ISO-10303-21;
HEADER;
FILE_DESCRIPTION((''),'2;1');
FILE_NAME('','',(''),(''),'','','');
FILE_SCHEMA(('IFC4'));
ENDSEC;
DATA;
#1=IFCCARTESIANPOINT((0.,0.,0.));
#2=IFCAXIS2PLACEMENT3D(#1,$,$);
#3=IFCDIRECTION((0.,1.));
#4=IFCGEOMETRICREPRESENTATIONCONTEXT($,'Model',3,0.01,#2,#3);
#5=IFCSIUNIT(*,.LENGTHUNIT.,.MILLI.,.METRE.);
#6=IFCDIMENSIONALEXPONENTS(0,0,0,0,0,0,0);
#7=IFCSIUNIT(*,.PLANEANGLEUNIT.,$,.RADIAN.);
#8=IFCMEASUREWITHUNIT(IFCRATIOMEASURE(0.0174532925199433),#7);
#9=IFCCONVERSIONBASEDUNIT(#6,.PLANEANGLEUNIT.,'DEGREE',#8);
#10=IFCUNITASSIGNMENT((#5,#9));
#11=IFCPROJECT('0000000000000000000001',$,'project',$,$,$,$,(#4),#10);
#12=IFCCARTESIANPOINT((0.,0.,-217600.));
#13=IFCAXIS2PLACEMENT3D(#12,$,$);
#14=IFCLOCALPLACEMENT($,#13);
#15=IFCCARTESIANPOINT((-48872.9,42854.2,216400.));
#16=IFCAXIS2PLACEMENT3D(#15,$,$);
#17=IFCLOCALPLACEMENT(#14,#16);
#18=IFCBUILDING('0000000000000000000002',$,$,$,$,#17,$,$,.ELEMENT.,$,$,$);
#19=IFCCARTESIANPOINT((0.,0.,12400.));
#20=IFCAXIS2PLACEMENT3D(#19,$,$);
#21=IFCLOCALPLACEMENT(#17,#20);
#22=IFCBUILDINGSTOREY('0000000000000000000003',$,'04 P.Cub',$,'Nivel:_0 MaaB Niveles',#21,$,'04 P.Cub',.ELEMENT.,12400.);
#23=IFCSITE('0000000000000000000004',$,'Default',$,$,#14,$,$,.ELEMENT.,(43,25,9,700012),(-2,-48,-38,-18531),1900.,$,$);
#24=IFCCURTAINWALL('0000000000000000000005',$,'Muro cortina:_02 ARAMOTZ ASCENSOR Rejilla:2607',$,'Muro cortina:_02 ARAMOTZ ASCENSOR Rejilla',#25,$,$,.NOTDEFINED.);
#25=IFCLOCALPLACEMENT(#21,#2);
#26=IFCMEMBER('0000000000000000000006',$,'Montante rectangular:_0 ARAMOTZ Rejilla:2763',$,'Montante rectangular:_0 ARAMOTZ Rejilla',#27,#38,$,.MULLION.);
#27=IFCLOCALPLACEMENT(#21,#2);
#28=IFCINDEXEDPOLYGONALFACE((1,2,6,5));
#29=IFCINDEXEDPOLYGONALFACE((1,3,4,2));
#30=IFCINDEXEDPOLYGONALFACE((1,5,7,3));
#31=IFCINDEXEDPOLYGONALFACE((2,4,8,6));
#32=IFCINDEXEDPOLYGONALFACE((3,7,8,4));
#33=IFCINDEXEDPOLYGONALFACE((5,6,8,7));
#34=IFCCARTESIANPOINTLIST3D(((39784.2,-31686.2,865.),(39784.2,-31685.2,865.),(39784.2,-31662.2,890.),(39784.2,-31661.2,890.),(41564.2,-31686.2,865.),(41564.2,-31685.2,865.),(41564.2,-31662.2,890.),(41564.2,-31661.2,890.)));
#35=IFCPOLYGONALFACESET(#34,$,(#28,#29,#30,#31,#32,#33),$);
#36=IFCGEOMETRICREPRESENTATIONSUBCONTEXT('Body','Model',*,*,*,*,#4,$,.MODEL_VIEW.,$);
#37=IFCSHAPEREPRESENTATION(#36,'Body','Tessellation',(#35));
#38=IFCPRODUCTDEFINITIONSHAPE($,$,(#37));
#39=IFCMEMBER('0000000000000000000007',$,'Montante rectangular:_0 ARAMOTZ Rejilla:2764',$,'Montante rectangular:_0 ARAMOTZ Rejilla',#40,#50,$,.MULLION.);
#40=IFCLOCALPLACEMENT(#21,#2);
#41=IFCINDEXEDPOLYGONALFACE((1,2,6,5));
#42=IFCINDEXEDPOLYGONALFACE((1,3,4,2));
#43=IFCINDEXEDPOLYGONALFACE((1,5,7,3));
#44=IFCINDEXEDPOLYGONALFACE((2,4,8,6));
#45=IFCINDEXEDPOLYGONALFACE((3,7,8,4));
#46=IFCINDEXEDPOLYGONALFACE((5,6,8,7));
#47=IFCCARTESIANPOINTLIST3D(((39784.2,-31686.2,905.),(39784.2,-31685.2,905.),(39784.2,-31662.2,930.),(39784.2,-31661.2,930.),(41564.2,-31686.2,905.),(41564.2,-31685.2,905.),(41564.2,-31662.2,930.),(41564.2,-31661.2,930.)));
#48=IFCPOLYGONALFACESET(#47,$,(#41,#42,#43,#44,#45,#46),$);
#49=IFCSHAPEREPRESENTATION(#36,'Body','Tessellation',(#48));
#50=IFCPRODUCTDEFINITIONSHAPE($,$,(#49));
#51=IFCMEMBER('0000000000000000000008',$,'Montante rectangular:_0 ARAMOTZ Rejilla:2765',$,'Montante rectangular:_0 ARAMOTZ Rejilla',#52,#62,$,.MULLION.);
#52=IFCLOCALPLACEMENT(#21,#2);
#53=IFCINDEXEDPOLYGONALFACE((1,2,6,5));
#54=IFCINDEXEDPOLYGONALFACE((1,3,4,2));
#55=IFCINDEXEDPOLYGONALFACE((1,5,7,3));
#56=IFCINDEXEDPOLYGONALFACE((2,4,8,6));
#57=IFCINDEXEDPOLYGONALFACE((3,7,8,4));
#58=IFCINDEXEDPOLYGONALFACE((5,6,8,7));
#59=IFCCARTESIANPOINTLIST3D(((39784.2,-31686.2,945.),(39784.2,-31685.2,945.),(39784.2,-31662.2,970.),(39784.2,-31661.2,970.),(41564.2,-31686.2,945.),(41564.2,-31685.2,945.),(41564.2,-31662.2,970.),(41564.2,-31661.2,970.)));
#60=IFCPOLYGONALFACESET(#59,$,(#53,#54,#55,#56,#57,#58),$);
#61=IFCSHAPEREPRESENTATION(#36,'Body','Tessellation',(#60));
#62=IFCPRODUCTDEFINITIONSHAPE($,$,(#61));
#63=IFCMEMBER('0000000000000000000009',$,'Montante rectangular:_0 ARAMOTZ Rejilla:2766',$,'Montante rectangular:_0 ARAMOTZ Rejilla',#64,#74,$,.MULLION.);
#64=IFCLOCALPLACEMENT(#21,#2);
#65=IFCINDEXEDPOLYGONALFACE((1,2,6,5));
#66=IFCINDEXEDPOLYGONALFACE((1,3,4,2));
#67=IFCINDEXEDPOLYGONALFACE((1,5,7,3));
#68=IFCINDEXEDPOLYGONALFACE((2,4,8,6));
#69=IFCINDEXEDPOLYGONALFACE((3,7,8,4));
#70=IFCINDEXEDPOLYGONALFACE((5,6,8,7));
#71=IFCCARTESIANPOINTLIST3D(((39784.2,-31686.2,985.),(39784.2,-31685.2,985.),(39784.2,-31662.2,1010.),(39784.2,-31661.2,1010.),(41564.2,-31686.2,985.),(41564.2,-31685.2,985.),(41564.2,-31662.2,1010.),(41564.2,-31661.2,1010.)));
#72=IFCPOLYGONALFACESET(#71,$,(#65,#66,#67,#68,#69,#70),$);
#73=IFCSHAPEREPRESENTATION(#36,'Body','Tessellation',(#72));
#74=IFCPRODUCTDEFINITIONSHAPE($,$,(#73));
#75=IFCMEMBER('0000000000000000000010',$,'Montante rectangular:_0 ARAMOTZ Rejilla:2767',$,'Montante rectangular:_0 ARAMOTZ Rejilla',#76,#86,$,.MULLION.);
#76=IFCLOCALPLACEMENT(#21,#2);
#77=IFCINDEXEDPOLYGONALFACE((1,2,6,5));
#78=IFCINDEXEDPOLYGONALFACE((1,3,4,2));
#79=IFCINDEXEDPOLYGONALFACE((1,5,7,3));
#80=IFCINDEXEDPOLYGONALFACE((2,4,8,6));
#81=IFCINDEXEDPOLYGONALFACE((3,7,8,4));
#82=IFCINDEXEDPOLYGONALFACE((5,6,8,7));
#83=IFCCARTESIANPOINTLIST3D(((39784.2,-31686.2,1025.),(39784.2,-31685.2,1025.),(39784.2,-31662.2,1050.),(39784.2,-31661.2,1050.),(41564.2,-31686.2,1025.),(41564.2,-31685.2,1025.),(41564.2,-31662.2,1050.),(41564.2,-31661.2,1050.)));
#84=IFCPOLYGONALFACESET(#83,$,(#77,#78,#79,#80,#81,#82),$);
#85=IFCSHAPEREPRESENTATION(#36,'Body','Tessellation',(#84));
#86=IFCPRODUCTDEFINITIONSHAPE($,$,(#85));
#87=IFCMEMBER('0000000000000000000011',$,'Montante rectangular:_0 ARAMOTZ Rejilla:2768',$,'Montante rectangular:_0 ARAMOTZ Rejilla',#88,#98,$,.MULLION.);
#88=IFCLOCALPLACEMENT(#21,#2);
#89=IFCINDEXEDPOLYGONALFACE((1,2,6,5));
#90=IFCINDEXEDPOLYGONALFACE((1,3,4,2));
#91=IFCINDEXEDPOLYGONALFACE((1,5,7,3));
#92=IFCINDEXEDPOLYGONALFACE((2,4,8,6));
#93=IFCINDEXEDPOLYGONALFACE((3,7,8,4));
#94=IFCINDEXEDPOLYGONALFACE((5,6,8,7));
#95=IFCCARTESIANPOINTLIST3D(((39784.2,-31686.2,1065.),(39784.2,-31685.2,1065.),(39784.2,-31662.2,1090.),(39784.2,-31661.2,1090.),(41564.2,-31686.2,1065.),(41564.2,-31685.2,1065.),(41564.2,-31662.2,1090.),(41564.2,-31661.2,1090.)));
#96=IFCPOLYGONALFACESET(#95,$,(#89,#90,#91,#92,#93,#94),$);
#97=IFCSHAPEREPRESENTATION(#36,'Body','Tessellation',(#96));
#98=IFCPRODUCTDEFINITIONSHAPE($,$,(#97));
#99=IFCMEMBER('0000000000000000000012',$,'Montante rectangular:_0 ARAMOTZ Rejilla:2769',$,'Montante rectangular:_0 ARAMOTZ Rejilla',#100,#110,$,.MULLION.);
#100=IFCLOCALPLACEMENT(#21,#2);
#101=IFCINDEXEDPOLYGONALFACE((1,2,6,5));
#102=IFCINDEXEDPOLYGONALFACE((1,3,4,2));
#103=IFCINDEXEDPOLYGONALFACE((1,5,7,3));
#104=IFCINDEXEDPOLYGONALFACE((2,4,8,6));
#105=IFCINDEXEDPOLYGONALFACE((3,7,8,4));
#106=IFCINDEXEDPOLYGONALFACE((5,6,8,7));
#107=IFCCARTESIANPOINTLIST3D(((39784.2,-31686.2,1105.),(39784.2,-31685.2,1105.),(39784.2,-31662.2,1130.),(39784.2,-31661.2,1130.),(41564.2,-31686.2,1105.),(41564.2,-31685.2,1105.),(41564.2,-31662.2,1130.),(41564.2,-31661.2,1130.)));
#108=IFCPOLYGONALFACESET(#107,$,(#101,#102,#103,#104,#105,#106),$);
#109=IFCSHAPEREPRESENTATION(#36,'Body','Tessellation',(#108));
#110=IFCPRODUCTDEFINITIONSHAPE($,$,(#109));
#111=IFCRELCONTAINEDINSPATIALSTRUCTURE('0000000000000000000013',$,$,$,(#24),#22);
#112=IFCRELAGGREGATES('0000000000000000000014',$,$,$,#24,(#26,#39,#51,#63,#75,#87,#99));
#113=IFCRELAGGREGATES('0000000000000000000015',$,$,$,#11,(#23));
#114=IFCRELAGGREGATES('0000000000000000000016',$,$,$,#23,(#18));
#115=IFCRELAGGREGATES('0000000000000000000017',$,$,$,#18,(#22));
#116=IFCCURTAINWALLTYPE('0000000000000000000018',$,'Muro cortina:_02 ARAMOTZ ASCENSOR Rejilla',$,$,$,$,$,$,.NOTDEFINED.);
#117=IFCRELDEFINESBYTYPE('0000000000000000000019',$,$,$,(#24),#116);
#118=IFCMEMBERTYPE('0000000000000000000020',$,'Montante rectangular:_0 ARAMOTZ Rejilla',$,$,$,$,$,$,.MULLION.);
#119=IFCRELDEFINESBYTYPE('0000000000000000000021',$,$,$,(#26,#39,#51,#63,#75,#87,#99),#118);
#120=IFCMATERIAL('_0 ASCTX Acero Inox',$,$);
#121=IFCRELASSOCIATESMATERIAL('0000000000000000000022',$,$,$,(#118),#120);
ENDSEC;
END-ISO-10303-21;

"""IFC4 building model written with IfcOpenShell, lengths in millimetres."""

from ifc_helpers import new_model, entity, si_unit, converted_unit, direction, frame, origin, place, context, subcontext, project, spatial, indexed_curve, outline, extrude, source, transform, mapped, material, type_object, type_shapes, element, aggregate, save


model = new_model("IFC4")

# Units and contexts
model_context = context("Model", 3, precision=0.01, world=origin(), true_north=direction((0.0, 1.0)))
body_context = subcontext(model_context, "Body", "Model", "MODEL_VIEW")
ifc_project = project(units=[si_unit("LENGTHUNIT", "METRE", prefix="MILLI"), converted_unit("PLANEANGLEUNIT", "DEGREE", entity("IfcRatioMeasure", 0.0174532925199433), si_unit("PLANEANGLEUNIT", "RADIAN"), dimensions=[0, 0, 0, 0, 0, 0, 0])], contexts=[model_context])

# Site, building, storey
site_placement = place(None, frame((0.0, 0.0, -217600.0)))
site = spatial("IfcSite", under=ifc_project, at=site_placement, Name="Default", CompositionType="ELEMENT", RefLatitude=(43, 25, 9, 700012), RefLongitude=(-2, -48, -38, -18531), RefElevation=1900.0)
building_placement = place(site_placement, frame((-48872.9, 42854.2, 216400.0)))
building = spatial("IfcBuilding", under=site, at=building_placement, CompositionType="ELEMENT")
storey_placement = place(building_placement, frame((0.0, 0.0, 12400.0)))
storey = spatial("IfcBuildingStorey", under=building, at=storey_placement, Name="04 P.Cub", ObjectType="Nivel:_0 MaaB Niveles", LongName="04 P.Cub", CompositionType="ELEMENT", Elevation=12400.0)

# Curtain wall, members
curtain_wall_type = type_object("IfcCurtainWallType", Name="Muro cortina:_02 ARAMOTZ ASCENSOR Rejilla", PredefinedType="NOTDEFINED")
curtain_wall_placement = place(storey_placement, frame((0.0, 0.0, -12400.0)))
curtain_wall = element("IfcCurtainWall", 1, at=curtain_wall_placement, inside=storey, type_object=curtain_wall_type, Name="Muro cortina:_02 ARAMOTZ ASCENSOR Rejilla:2607", ObjectType="Muro cortina:_02 ARAMOTZ ASCENSOR Rejilla", PredefinedType="NOTDEFINED")
ifc_material_1 = material(Name="_0 ASCTX Acero Inox")
member_type = type_object("IfcMemberType", Name="Montante rectangular:_0 ARAMOTZ Rejilla", PredefinedType="MULLION", material=ifc_material_1)
shared_shape_1 = source(origin(), body_context, "Body", "SweptSolid", [
    extrude(outline(indexed_curve([(11.5, -12.5), (12.5, -12.5), (-11.5, 12.5), (-12.5, 12.5), (11.5, -12.5)], self_intersect=False)), frame((-12.5, -22.5, -1780.0), z_axis=(0.0, 0.0, 1.0), x_axis=(0.0, -1.0, 0.0)), (0.0, 0.0, 1.0), 1780.0),
])
type_shapes(member_type, [shared_shape_1])
member_1_placement = place(curtain_wall_placement, frame((39784.2, -31651.2, 13290.0), z_axis=(-1.0, 0.0, 0.0), x_axis=(0.0, 0.0, 1.0)))
member_1 = element("IfcMember", 2, at=member_1_placement, type_object=member_type, Name="Montante rectangular:_0 ARAMOTZ Rejilla:2763", ObjectType="Montante rectangular:_0 ARAMOTZ Rejilla", PredefinedType="MULLION", context=body_context, shape_type="MappedRepresentation", body=[
    mapped(shared_shape_1, transform((0.0, 0.0, 0.0), scale=1.0)),
])
member_2_placement = place(curtain_wall_placement, frame((39784.2, -31651.2, 13330.0), z_axis=(-1.0, 0.0, 0.0), x_axis=(0.0, 0.0, 1.0)))
member_2 = element("IfcMember", 3, at=member_2_placement, type_object=member_type, Name="Montante rectangular:_0 ARAMOTZ Rejilla:2764", ObjectType="Montante rectangular:_0 ARAMOTZ Rejilla", PredefinedType="MULLION", context=body_context, shape_type="MappedRepresentation", body=[
    mapped(shared_shape_1, transform((0.0, 0.0, 0.0), scale=1.0)),
])
member_3_placement = place(curtain_wall_placement, frame((39784.2, -31651.2, 13370.0), z_axis=(-1.0, 0.0, 0.0), x_axis=(0.0, 0.0, 1.0)))
member_3 = element("IfcMember", 4, at=member_3_placement, type_object=member_type, Name="Montante rectangular:_0 ARAMOTZ Rejilla:2765", ObjectType="Montante rectangular:_0 ARAMOTZ Rejilla", PredefinedType="MULLION", context=body_context, shape_type="MappedRepresentation", body=[
    mapped(shared_shape_1, transform((0.0, 0.0, 0.0), scale=1.0)),
])
member_4_placement = place(curtain_wall_placement, frame((39784.2, -31651.2, 13410.0), z_axis=(-1.0, 0.0, 0.0), x_axis=(0.0, 0.0, 1.0)))
member_4 = element("IfcMember", 5, at=member_4_placement, type_object=member_type, Name="Montante rectangular:_0 ARAMOTZ Rejilla:2766", ObjectType="Montante rectangular:_0 ARAMOTZ Rejilla", PredefinedType="MULLION", context=body_context, shape_type="MappedRepresentation", body=[
    mapped(shared_shape_1, transform((0.0, 0.0, 0.0), scale=1.0)),
])
member_5_placement = place(curtain_wall_placement, frame((39784.2, -31651.2, 13450.0), z_axis=(-1.0, 0.0, 0.0), x_axis=(0.0, 0.0, 1.0)))
member_5 = element("IfcMember", 6, at=member_5_placement, type_object=member_type, Name="Montante rectangular:_0 ARAMOTZ Rejilla:2767", ObjectType="Montante rectangular:_0 ARAMOTZ Rejilla", PredefinedType="MULLION", context=body_context, shape_type="MappedRepresentation", body=[
    mapped(shared_shape_1, transform((0.0, 0.0, 0.0), scale=1.0)),
])
member_6_placement = place(curtain_wall_placement, frame((39784.2, -31651.2, 13490.0), z_axis=(-1.0, 0.0, 0.0), x_axis=(0.0, 0.0, 1.0)))
member_6 = element("IfcMember", 7, at=member_6_placement, type_object=member_type, Name="Montante rectangular:_0 ARAMOTZ Rejilla:2768", ObjectType="Montante rectangular:_0 ARAMOTZ Rejilla", PredefinedType="MULLION", context=body_context, shape_type="MappedRepresentation", body=[
    mapped(shared_shape_1, transform((0.0, 0.0, 0.0), scale=1.0)),
])
member_7_placement = place(curtain_wall_placement, frame((39784.2, -31651.2, 13530.0), z_axis=(-1.0, 0.0, 0.0), x_axis=(0.0, 0.0, 1.0)))
member_7 = element("IfcMember", 8, at=member_7_placement, type_object=member_type, Name="Montante rectangular:_0 ARAMOTZ Rejilla:2769", ObjectType="Montante rectangular:_0 ARAMOTZ Rejilla", PredefinedType="MULLION", context=body_context, shape_type="MappedRepresentation", body=[
    mapped(shared_shape_1, transform((0.0, 0.0, 0.0), scale=1.0)),
])

aggregate(curtain_wall, [member_1, member_2, member_3, member_4, member_5, member_6, member_7])

save(model, "model.ifc")
